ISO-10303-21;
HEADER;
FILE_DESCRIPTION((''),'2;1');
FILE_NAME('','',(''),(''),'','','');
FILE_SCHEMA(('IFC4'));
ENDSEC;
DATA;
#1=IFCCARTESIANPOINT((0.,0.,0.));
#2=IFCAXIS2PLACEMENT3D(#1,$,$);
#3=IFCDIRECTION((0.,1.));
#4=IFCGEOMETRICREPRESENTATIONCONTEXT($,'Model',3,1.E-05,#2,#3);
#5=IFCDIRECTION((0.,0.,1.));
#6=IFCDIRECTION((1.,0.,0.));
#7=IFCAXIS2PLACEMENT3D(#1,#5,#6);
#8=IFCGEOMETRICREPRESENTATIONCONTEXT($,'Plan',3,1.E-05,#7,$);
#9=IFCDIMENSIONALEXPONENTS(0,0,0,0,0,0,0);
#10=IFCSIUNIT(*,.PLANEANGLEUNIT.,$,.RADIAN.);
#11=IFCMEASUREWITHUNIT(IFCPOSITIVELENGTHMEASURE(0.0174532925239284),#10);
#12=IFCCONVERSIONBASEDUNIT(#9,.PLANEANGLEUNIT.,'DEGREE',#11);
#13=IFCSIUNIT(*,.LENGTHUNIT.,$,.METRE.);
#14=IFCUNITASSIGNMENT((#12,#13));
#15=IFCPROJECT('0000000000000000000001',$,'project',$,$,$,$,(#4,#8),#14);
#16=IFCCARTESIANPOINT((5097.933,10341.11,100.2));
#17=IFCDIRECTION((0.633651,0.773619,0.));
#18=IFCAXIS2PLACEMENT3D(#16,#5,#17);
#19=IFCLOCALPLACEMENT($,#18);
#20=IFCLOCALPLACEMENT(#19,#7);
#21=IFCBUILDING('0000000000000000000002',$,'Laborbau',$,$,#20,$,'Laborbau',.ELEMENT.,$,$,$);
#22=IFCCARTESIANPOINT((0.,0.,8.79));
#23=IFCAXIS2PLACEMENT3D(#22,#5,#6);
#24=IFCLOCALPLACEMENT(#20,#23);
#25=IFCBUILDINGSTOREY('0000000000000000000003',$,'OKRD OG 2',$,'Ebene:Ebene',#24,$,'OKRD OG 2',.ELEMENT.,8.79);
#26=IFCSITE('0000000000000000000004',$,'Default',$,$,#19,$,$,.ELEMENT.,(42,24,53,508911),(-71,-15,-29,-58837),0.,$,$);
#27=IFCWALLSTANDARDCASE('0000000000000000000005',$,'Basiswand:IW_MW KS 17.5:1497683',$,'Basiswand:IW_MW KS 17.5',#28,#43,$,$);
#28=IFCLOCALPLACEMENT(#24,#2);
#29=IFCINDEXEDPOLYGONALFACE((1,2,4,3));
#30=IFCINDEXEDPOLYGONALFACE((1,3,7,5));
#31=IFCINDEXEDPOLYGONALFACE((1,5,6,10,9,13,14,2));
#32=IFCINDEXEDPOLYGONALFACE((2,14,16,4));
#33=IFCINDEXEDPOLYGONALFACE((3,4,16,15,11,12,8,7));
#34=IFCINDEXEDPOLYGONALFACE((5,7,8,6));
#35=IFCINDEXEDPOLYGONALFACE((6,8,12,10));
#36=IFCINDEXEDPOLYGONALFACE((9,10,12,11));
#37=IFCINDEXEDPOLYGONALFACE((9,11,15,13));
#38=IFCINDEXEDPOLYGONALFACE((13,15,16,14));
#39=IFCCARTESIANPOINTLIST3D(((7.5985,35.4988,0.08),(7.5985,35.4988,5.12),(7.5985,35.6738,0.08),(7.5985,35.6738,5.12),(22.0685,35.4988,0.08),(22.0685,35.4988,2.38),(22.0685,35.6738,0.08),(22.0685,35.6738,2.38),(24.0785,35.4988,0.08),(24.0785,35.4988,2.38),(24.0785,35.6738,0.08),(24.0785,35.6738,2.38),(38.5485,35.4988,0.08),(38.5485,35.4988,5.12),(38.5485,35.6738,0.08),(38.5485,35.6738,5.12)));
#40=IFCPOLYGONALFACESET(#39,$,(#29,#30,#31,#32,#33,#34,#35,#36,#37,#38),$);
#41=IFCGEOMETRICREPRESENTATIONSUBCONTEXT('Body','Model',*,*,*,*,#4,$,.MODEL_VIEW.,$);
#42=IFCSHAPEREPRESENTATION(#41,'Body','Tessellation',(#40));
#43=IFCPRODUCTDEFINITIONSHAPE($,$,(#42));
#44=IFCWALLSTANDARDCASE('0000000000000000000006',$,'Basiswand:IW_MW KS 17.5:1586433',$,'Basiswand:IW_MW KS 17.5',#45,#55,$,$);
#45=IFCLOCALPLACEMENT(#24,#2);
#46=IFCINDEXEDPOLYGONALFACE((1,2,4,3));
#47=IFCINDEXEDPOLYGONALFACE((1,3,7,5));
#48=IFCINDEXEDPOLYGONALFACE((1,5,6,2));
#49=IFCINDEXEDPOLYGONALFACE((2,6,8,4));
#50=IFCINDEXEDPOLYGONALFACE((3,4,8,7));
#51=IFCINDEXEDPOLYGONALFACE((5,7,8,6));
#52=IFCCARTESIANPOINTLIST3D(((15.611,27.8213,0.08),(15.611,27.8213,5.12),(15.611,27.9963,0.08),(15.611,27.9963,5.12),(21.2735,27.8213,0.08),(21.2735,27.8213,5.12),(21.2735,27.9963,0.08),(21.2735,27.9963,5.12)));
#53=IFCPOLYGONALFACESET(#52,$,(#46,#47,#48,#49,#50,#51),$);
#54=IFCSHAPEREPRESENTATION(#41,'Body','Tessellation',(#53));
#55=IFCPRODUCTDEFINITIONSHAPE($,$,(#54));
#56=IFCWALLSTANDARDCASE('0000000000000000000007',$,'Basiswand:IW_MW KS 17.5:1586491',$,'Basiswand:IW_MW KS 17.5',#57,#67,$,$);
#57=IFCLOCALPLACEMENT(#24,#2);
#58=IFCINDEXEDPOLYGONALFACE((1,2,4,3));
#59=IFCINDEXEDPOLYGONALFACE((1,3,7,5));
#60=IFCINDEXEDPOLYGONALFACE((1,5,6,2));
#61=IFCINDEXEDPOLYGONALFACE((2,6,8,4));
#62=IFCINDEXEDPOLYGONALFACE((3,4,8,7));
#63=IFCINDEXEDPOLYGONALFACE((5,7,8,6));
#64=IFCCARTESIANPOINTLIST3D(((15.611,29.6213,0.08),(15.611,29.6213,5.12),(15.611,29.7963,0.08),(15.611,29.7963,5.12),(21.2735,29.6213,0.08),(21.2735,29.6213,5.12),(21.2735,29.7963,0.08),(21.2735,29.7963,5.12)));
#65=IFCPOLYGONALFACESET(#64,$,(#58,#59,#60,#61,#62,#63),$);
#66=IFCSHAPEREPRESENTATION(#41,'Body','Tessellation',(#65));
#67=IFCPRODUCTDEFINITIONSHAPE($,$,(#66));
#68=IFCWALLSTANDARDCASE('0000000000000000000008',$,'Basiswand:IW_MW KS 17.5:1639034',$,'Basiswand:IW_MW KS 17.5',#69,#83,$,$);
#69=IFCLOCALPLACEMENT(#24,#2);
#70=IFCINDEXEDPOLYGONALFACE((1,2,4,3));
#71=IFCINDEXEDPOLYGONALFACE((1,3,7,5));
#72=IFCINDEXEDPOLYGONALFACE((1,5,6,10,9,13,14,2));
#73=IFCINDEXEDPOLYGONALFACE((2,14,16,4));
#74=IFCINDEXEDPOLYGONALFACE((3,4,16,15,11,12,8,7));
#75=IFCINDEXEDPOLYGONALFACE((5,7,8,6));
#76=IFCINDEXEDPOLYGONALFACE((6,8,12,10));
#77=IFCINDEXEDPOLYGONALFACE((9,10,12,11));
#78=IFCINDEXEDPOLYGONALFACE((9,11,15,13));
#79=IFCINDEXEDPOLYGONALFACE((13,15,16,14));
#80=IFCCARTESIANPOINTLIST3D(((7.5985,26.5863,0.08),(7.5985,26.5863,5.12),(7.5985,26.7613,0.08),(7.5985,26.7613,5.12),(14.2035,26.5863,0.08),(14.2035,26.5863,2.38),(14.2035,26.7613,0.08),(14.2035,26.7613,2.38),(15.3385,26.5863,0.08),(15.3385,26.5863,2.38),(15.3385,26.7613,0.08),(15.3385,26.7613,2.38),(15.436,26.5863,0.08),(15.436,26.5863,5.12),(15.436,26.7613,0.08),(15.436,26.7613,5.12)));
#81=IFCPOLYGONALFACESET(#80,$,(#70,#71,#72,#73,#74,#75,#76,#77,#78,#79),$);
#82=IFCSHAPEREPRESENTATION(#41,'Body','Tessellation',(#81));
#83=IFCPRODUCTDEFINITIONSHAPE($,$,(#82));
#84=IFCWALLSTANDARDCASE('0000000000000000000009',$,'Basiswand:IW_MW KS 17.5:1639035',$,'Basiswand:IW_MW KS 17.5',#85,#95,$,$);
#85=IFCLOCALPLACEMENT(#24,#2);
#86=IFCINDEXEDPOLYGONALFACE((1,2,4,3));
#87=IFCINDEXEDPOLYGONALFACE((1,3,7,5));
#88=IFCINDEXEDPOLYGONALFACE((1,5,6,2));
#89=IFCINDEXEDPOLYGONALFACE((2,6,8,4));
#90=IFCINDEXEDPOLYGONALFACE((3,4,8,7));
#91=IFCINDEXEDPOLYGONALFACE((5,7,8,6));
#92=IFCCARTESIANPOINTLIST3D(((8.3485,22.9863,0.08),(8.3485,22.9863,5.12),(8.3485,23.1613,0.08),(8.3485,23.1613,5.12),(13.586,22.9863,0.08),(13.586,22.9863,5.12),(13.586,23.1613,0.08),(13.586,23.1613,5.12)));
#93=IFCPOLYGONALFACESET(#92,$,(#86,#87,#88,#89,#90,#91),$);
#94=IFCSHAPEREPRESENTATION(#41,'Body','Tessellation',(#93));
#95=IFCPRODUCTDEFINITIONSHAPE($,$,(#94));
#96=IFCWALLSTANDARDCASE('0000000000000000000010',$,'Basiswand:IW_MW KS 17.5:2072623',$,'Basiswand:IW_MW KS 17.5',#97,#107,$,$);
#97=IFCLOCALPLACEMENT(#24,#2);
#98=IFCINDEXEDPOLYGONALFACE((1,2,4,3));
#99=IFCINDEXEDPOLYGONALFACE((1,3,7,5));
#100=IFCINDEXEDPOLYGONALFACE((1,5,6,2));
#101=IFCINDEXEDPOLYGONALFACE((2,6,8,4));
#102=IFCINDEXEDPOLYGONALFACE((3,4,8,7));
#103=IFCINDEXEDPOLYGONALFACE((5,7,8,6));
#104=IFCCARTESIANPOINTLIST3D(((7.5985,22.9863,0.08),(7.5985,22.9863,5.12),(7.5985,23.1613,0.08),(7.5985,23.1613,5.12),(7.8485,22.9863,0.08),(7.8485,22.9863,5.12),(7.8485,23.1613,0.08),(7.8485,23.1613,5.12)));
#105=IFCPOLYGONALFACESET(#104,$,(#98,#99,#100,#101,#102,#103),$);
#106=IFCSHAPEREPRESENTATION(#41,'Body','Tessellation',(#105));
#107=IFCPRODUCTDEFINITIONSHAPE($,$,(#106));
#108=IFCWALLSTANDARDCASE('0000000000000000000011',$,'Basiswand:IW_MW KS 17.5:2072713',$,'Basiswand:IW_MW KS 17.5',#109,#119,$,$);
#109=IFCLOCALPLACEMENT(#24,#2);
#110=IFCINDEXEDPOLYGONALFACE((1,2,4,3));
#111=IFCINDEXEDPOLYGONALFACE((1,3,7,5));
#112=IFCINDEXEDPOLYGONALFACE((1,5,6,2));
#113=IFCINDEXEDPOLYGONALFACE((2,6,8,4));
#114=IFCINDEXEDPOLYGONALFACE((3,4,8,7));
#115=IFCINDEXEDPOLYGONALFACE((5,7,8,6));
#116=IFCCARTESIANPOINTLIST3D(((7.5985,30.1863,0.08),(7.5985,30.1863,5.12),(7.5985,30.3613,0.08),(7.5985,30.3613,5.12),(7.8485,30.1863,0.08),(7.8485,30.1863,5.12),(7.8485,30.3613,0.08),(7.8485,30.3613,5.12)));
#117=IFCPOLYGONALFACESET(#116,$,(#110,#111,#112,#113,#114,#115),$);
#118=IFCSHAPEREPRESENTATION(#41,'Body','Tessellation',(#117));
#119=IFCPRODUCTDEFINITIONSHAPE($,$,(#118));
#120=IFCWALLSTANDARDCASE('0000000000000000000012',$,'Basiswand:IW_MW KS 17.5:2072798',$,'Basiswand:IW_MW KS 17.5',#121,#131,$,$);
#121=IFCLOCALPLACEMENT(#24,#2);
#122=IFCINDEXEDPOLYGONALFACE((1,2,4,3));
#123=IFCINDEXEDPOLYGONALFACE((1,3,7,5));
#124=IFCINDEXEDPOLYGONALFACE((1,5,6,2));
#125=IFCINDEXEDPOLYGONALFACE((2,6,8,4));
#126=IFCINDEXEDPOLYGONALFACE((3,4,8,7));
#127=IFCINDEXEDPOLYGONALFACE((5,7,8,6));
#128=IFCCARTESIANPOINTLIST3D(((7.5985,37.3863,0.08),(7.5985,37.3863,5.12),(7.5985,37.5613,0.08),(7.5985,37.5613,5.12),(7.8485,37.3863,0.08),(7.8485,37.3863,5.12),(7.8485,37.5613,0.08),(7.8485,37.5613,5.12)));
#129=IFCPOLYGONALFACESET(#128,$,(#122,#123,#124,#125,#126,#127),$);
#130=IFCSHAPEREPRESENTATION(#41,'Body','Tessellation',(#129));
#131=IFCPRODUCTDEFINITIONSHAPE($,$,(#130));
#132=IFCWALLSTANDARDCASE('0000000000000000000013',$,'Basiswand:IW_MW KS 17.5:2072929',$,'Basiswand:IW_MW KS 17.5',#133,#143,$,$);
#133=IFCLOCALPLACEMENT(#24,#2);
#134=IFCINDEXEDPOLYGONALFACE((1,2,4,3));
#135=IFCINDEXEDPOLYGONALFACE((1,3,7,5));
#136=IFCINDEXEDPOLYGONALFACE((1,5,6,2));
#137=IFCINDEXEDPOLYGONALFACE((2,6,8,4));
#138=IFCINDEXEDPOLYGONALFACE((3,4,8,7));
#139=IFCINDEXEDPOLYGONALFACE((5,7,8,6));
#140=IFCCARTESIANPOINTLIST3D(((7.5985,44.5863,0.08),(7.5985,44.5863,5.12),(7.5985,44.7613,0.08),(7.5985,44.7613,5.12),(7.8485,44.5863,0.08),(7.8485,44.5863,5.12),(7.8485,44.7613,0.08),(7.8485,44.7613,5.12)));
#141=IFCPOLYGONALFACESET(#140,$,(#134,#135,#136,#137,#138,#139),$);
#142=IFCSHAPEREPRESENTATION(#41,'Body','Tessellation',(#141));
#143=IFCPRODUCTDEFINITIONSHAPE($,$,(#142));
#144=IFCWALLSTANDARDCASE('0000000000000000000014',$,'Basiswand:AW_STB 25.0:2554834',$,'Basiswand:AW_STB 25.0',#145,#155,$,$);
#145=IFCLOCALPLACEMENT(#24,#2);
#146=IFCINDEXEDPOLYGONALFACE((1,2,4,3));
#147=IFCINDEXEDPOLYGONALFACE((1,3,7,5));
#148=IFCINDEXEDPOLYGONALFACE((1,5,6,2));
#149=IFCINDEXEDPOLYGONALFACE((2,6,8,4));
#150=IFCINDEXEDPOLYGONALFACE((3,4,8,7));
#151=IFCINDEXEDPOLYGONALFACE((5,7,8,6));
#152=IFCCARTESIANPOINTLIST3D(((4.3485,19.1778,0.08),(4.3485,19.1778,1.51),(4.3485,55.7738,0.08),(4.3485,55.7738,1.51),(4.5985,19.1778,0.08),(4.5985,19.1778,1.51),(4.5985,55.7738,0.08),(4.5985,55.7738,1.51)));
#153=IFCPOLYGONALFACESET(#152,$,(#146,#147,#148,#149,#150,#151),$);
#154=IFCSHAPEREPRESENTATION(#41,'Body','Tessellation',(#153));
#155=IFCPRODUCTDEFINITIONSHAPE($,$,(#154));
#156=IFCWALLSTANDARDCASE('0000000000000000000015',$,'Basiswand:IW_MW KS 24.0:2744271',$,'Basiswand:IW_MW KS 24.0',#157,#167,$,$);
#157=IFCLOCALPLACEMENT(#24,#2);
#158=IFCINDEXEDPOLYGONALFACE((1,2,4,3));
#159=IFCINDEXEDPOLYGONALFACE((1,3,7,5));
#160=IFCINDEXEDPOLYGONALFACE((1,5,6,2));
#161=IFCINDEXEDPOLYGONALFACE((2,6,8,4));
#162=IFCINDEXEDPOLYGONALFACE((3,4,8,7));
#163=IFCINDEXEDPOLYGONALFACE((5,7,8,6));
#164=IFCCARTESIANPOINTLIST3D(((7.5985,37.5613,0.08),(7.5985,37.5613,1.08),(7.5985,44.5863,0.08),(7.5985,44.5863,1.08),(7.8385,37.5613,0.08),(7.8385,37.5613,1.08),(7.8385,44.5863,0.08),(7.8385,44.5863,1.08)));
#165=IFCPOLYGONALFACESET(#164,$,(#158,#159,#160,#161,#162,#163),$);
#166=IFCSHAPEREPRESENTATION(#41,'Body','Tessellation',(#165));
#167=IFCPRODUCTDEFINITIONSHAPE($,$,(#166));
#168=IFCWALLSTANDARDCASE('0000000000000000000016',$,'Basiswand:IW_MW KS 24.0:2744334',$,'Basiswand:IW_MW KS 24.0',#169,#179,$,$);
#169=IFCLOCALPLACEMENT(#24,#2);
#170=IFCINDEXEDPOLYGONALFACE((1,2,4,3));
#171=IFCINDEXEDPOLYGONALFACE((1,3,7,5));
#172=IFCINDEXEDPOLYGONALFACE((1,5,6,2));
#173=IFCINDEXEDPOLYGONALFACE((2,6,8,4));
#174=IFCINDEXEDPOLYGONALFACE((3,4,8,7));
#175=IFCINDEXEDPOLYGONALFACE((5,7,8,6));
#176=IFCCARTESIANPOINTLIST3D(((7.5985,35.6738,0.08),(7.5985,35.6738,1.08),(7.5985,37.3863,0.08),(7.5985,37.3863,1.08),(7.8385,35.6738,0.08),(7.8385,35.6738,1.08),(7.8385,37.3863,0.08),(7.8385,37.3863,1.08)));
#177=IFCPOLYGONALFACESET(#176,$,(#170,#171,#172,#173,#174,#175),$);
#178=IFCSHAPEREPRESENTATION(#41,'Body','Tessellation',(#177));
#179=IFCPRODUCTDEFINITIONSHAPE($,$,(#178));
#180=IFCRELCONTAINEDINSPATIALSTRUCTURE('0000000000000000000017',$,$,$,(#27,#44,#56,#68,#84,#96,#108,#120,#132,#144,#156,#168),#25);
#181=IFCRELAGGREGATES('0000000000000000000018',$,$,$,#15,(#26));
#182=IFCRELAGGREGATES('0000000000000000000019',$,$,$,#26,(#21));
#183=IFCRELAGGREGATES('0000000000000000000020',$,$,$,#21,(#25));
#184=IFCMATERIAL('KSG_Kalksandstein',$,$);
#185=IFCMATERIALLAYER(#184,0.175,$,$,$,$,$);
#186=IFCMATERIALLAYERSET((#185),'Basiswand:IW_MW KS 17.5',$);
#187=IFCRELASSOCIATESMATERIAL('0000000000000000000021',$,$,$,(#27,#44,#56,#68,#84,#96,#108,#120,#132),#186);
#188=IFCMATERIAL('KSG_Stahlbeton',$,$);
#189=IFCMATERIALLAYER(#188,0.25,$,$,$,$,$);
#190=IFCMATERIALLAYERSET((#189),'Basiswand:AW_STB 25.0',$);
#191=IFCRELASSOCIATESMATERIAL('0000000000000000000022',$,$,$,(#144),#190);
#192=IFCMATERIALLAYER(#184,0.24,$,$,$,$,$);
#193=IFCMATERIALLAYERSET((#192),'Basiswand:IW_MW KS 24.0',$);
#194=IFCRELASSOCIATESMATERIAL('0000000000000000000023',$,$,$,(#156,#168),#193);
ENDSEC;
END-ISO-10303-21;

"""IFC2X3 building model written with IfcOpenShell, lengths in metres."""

from ifc_helpers import new_model, entity, si_unit, converted_unit, direction, frame, frame_2d, origin, origin_with_axes, place, context, subcontext, project, spatial, rectangle, extrude, material, layer, layer_set, layer_usage, element, save


model = new_model("IFC2X3")

# Units and contexts
model_context = context("Model", 3, precision=1e-05, world=origin(), true_north=direction((0.0, 1.0)))
plan_context = context("Plan", 3, precision=1e-05, world=origin_with_axes())
body_context = subcontext(model_context, "Body", "Model", "MODEL_VIEW")
ifc_project = project(units=[converted_unit("PLANEANGLEUNIT", "DEGREE", entity("IfcPositiveLengthMeasure", 0.0174532925239284), si_unit("PLANEANGLEUNIT", "RADIAN"), dimensions=[0, 0, 0, 0, 0, 0, 0]), si_unit("LENGTHUNIT", "METRE")], contexts=[model_context, plan_context])

# Site, building, storey
site_placement = place(None, frame((5097.933, 10341.11, 100.2), z_axis=(0.0, 0.0, 1.0), x_axis=(0.633651, 0.773619, 0.0)))
site = spatial("IfcSite", under=ifc_project, at=site_placement, Name="Default", CompositionType="ELEMENT", RefLatitude=(42, 24, 53, 508911), RefLongitude=(-71, -15, -29, -58837), RefElevation=0.0)
building_placement = place(site_placement, origin_with_axes())
building = spatial("IfcBuilding", under=site, at=building_placement, Name="Laborbau", LongName="Laborbau", CompositionType="ELEMENT")
storey_placement = place(building_placement, frame((0.0, 0.0, 8.79), z_axis=(0.0, 0.0, 1.0), x_axis=(1.0, 0.0, 0.0)))
storey = spatial("IfcBuildingStorey", under=building, at=storey_placement, Name="OKRD OG 2", ObjectType="Ebene:Ebene", LongName="OKRD OG 2", CompositionType="ELEMENT", Elevation=8.79)

# Wall, openings
ifc_material_1 = material(Name="KSG_Kalksandstein")
ifc_layer_1 = layer(ifc_material_1, 0.175)
ifc_layer_set_1 = layer_set([ifc_layer_1], Name="Basiswand:IW_MW KS 17.5")
ifc_layer_usage_1 = layer_usage(ifc_layer_set_1, "AXIS2", "NEGATIVE", 0.0875)
wall_1_placement = place(storey_placement, frame((7.5985, 35.5863, 0.08), z_axis=(0.0, 0.0, 1.0), x_axis=(1.0, 0.0, 0.0)))
wall_1 = element("IfcWallStandardCase", 1, at=wall_1_placement, inside=storey, material=ifc_layer_usage_1, Name="Basiswand:IW_MW KS 17.5:1497683", ObjectType="Basiswand:IW_MW KS 17.5", context=body_context, shape_type="SweptSolid", body=[
    extrude(rectangle(XDim=30.95, YDim=0.175, at=frame_2d((15.475, 0.0), x_axis=(-1.0, 0.0))), origin(), (0.0, 0.0, 1.0), 5.04),
])
opening_1_placement = place(wall_1_placement, frame((-7.5985, -35.5863, -0.08), z_axis=(0.0, 0.0, 1.0), x_axis=(1.0, 0.0, 0.0)))
element("IfcOpeningElement", 2, at=opening_1_placement, cuts=wall_1, ObjectType="Opening", context=body_context, shape_type="SweptSolid", body=[
    extrude(rectangle(XDim=2.38, YDim=2.01, at=frame_2d((0.0, 0.0), x_axis=(1.0, 0.0))), frame((23.0735, 34.1498, 1.19), z_axis=(0.0, 1.0, 0.0), x_axis=(0.0, 0.0, 1.0)), (0.0, 0.0, 1.0), 3.048),
])
opening_2_placement = place(wall_1_placement, frame((16.48, 0.0875, -0.08), z_axis=(0.0, 0.0, 1.0), x_axis=(1.0, 0.0, 0.0)))
element("IfcOpeningElement", 3, at=opening_2_placement, cuts=wall_1, ObjectType="Opening", context=body_context, shape_type="SweptSolid", body=[
    extrude(rectangle(XDim=2.38, YDim=2.01, at=frame_2d((1.19, 1.005), x_axis=(1.0, 0.0))), frame((0.0, 0.0, 0.0), z_axis=(0.0, -1.0, 0.0), x_axis=(0.0, 0.0, 1.0)), (0.0, 0.0, 1.0), 0.175),
])

# Walls
ifc_layer_usage_2 = layer_usage(ifc_layer_set_1, "AXIS2", "NEGATIVE", 0.0875)
wall_2_placement = place(storey_placement, frame((15.611, 27.9088, 0.08), z_axis=(0.0, 0.0, 1.0), x_axis=(1.0, 0.0, 0.0)))
element("IfcWallStandardCase", 4, at=wall_2_placement, inside=storey, material=ifc_layer_usage_2, Name="Basiswand:IW_MW KS 17.5:1586433", ObjectType="Basiswand:IW_MW KS 17.5", context=body_context, shape_type="SweptSolid", body=[
    extrude(rectangle(XDim=5.6625, YDim=0.175, at=frame_2d((2.8312, 0.0), x_axis=(-1.0, 0.0))), origin(), (0.0, 0.0, 1.0), 5.04),
])
ifc_layer_usage_3 = layer_usage(ifc_layer_set_1, "AXIS2", "NEGATIVE", 0.0875)
wall_3_placement = place(storey_placement, frame((15.611, 29.7088, 0.08), z_axis=(0.0, 0.0, 1.0), x_axis=(1.0, 0.0, 0.0)))
element("IfcWallStandardCase", 5, at=wall_3_placement, inside=storey, material=ifc_layer_usage_3, Name="Basiswand:IW_MW KS 17.5:1586491", ObjectType="Basiswand:IW_MW KS 17.5", context=body_context, shape_type="SweptSolid", body=[
    extrude(rectangle(XDim=5.6625, YDim=0.175, at=frame_2d((2.8312, 0.0), x_axis=(-1.0, 0.0))), origin(), (0.0, 0.0, 1.0), 5.04),
])

# Wall, openings
ifc_layer_usage_4 = layer_usage(ifc_layer_set_1, "AXIS2", "NEGATIVE", 0.0875)
wall_4_placement = place(storey_placement, frame((7.5985, 26.6738, 0.08), z_axis=(0.0, 0.0, 1.0), x_axis=(1.0, 0.0, 0.0)))
wall_4 = element("IfcWallStandardCase", 6, at=wall_4_placement, inside=storey, material=ifc_layer_usage_4, Name="Basiswand:IW_MW KS 17.5:1639034", ObjectType="Basiswand:IW_MW KS 17.5", context=body_context, shape_type="SweptSolid", body=[
    extrude(rectangle(XDim=7.8375, YDim=0.175, at=frame_2d((3.9188, 0.0), x_axis=(-1.0, 0.0))), origin(), (0.0, 0.0, 1.0), 5.04),
])
opening_3_placement = place(wall_4_placement, frame((-7.5985, -26.6738, -0.08), z_axis=(0.0, 0.0, 1.0), x_axis=(1.0, 0.0, 0.0)))
element("IfcOpeningElement", 7, at=opening_3_placement, cuts=wall_4, ObjectType="Opening", context=body_context, shape_type="SweptSolid", body=[
    extrude(rectangle(XDim=2.38, YDim=1.135, at=frame_2d((0.0, 0.0), x_axis=(1.0, 0.0))), frame((14.771, 25.0623, 1.19), z_axis=(0.0, 1.0, 0.0), x_axis=(0.0, 0.0, 1.0)), (0.0, 0.0, 1.0), 3.048),
])
opening_4_placement = place(wall_4_placement, frame((6.605, -0.0875, -0.08), z_axis=(0.0, 0.0, 1.0), x_axis=(1.0, 0.0, 0.0)))
element("IfcOpeningElement", 8, at=opening_4_placement, cuts=wall_4, ObjectType="Opening", context=body_context, shape_type="SweptSolid", body=[
    extrude(rectangle(XDim=2.38, YDim=1.135, at=frame_2d((1.19, 0.5675), x_axis=(1.0, 0.0))), frame((0.0, 0.0, 0.0), z_axis=(0.0, 1.0, 0.0), x_axis=(0.0, 0.0, 1.0)), (0.0, 0.0, 1.0), 0.175),
])

# Walls
ifc_layer_usage_5 = layer_usage(ifc_layer_set_1, "AXIS2", "NEGATIVE", 0.0875)
wall_5_placement = place(storey_placement, frame((8.3485, 23.0738, 0.08), z_axis=(0.0, 0.0, 1.0), x_axis=(1.0, 0.0, 0.0)))
element("IfcWallStandardCase", 9, at=wall_5_placement, inside=storey, material=ifc_layer_usage_5, Name="Basiswand:IW_MW KS 17.5:1639035", ObjectType="Basiswand:IW_MW KS 17.5", context=body_context, shape_type="SweptSolid", body=[
    extrude(rectangle(XDim=5.2375, YDim=0.175, at=frame_2d((2.6187, 0.0), x_axis=(-1.0, 0.0))), origin(), (0.0, 0.0, 1.0), 5.04),
])
ifc_layer_usage_6 = layer_usage(ifc_layer_set_1, "AXIS2", "NEGATIVE", 0.0875)
wall_6_placement = place(storey_placement, frame((7.8485, 23.0738, 0.08), z_axis=(0.0, 0.0, 1.0), x_axis=(-1.0, 0.0, 0.0)))
element("IfcWallStandardCase", 10, at=wall_6_placement, inside=storey, material=ifc_layer_usage_6, Name="Basiswand:IW_MW KS 17.5:2072623", ObjectType="Basiswand:IW_MW KS 17.5", context=body_context, shape_type="SweptSolid", body=[
    extrude(rectangle(XDim=0.25, YDim=0.175, at=frame_2d((0.125, 0.0), x_axis=(-1.0, 0.0))), origin(), (0.0, 0.0, 1.0), 5.04),
])
ifc_layer_usage_7 = layer_usage(ifc_layer_set_1, "AXIS2", "NEGATIVE", 0.0875)
wall_7_placement = place(storey_placement, frame((7.8485, 30.2738, 0.08), z_axis=(0.0, 0.0, 1.0), x_axis=(-1.0, 0.0, 0.0)))
element("IfcWallStandardCase", 11, at=wall_7_placement, inside=storey, material=ifc_layer_usage_7, Name="Basiswand:IW_MW KS 17.5:2072713", ObjectType="Basiswand:IW_MW KS 17.5", context=body_context, shape_type="SweptSolid", body=[
    extrude(rectangle(XDim=0.25, YDim=0.175, at=frame_2d((0.125, 0.0), x_axis=(-1.0, 0.0))), origin(), (0.0, 0.0, 1.0), 5.04),
])
ifc_layer_usage_8 = layer_usage(ifc_layer_set_1, "AXIS2", "NEGATIVE", 0.0875)
wall_8_placement = place(storey_placement, frame((7.8485, 37.4738, 0.08), z_axis=(0.0, 0.0, 1.0), x_axis=(-1.0, 0.0, 0.0)))
element("IfcWallStandardCase", 12, at=wall_8_placement, inside=storey, material=ifc_layer_usage_8, Name="Basiswand:IW_MW KS 17.5:2072798", ObjectType="Basiswand:IW_MW KS 17.5", context=body_context, shape_type="SweptSolid", body=[
    extrude(rectangle(XDim=0.25, YDim=0.175, at=frame_2d((0.125, 0.0), x_axis=(-1.0, 0.0))), origin(), (0.0, 0.0, 1.0), 5.04),
])
ifc_layer_usage_9 = layer_usage(ifc_layer_set_1, "AXIS2", "NEGATIVE", 0.0875)
wall_9_placement = place(storey_placement, frame((7.8485, 44.6738, 0.08), z_axis=(0.0, 0.0, 1.0), x_axis=(-1.0, 0.0, 0.0)))
element("IfcWallStandardCase", 13, at=wall_9_placement, inside=storey, material=ifc_layer_usage_9, Name="Basiswand:IW_MW KS 17.5:2072929", ObjectType="Basiswand:IW_MW KS 17.5", context=body_context, shape_type="SweptSolid", body=[
    extrude(rectangle(XDim=0.25, YDim=0.175, at=frame_2d((0.125, 0.0), x_axis=(-1.0, 0.0))), origin(), (0.0, 0.0, 1.0), 5.04),
])
ifc_material_2 = material(Name="KSG_Stahlbeton")
ifc_layer_2 = layer(ifc_material_2, 0.25)
ifc_layer_set_2 = layer_set([ifc_layer_2], Name="Basiswand:AW_STB 25.0")
ifc_layer_usage_10 = layer_usage(ifc_layer_set_2, "AXIS2", "NEGATIVE", 0.125)
wall_10_placement = place(storey_placement, frame((4.4735, 19.1778, 0.08), z_axis=(0.0, 0.0, 1.0), x_axis=(0.0, 1.0, 0.0)))
element("IfcWallStandardCase", 14, at=wall_10_placement, inside=storey, material=ifc_layer_usage_10, Name="Basiswand:AW_STB 25.0:2554834", ObjectType="Basiswand:AW_STB 25.0", context=body_context, shape_type="SweptSolid", body=[
    extrude(rectangle(XDim=36.596, YDim=0.25, at=frame_2d((18.298, 0.0), x_axis=(-1.0, 0.0))), origin(), (0.0, 0.0, 1.0), 1.43),
])
ifc_layer_3 = layer(ifc_material_1, 0.24)
ifc_layer_set_3 = layer_set([ifc_layer_3], Name="Basiswand:IW_MW KS 24.0")
ifc_layer_usage_11 = layer_usage(ifc_layer_set_3, "AXIS2", "NEGATIVE", 0.12)
wall_11_placement = place(storey_placement, frame((7.7185, 44.5863, 0.08), z_axis=(0.0, 0.0, 1.0), x_axis=(0.0, -1.0, 0.0)))
element("IfcWallStandardCase", 15, at=wall_11_placement, inside=storey, material=ifc_layer_usage_11, Name="Basiswand:IW_MW KS 24.0:2744271", ObjectType="Basiswand:IW_MW KS 24.0", context=body_context, shape_type="SweptSolid", body=[
    extrude(rectangle(XDim=7.025, YDim=0.24, at=frame_2d((3.5125, 0.0), x_axis=(-1.0, 0.0))), origin(), (0.0, 0.0, 1.0), 1.0),
])
ifc_layer_usage_12 = layer_usage(ifc_layer_set_3, "AXIS2", "NEGATIVE", 0.12)
wall_12_placement = place(storey_placement, frame((7.7185, 37.3863, 0.08), z_axis=(0.0, 0.0, 1.0), x_axis=(0.0, -1.0, 0.0)))
element("IfcWallStandardCase", 16, at=wall_12_placement, inside=storey, material=ifc_layer_usage_12, Name="Basiswand:IW_MW KS 24.0:2744334", ObjectType="Basiswand:IW_MW KS 24.0", context=body_context, shape_type="SweptSolid", body=[
    extrude(rectangle(XDim=1.7125, YDim=0.24, at=frame_2d((0.8563, 0.0), x_axis=(-1.0, 0.0))), origin(), (0.0, 0.0, 1.0), 1.0),
])

save(model, "model.ifc")
